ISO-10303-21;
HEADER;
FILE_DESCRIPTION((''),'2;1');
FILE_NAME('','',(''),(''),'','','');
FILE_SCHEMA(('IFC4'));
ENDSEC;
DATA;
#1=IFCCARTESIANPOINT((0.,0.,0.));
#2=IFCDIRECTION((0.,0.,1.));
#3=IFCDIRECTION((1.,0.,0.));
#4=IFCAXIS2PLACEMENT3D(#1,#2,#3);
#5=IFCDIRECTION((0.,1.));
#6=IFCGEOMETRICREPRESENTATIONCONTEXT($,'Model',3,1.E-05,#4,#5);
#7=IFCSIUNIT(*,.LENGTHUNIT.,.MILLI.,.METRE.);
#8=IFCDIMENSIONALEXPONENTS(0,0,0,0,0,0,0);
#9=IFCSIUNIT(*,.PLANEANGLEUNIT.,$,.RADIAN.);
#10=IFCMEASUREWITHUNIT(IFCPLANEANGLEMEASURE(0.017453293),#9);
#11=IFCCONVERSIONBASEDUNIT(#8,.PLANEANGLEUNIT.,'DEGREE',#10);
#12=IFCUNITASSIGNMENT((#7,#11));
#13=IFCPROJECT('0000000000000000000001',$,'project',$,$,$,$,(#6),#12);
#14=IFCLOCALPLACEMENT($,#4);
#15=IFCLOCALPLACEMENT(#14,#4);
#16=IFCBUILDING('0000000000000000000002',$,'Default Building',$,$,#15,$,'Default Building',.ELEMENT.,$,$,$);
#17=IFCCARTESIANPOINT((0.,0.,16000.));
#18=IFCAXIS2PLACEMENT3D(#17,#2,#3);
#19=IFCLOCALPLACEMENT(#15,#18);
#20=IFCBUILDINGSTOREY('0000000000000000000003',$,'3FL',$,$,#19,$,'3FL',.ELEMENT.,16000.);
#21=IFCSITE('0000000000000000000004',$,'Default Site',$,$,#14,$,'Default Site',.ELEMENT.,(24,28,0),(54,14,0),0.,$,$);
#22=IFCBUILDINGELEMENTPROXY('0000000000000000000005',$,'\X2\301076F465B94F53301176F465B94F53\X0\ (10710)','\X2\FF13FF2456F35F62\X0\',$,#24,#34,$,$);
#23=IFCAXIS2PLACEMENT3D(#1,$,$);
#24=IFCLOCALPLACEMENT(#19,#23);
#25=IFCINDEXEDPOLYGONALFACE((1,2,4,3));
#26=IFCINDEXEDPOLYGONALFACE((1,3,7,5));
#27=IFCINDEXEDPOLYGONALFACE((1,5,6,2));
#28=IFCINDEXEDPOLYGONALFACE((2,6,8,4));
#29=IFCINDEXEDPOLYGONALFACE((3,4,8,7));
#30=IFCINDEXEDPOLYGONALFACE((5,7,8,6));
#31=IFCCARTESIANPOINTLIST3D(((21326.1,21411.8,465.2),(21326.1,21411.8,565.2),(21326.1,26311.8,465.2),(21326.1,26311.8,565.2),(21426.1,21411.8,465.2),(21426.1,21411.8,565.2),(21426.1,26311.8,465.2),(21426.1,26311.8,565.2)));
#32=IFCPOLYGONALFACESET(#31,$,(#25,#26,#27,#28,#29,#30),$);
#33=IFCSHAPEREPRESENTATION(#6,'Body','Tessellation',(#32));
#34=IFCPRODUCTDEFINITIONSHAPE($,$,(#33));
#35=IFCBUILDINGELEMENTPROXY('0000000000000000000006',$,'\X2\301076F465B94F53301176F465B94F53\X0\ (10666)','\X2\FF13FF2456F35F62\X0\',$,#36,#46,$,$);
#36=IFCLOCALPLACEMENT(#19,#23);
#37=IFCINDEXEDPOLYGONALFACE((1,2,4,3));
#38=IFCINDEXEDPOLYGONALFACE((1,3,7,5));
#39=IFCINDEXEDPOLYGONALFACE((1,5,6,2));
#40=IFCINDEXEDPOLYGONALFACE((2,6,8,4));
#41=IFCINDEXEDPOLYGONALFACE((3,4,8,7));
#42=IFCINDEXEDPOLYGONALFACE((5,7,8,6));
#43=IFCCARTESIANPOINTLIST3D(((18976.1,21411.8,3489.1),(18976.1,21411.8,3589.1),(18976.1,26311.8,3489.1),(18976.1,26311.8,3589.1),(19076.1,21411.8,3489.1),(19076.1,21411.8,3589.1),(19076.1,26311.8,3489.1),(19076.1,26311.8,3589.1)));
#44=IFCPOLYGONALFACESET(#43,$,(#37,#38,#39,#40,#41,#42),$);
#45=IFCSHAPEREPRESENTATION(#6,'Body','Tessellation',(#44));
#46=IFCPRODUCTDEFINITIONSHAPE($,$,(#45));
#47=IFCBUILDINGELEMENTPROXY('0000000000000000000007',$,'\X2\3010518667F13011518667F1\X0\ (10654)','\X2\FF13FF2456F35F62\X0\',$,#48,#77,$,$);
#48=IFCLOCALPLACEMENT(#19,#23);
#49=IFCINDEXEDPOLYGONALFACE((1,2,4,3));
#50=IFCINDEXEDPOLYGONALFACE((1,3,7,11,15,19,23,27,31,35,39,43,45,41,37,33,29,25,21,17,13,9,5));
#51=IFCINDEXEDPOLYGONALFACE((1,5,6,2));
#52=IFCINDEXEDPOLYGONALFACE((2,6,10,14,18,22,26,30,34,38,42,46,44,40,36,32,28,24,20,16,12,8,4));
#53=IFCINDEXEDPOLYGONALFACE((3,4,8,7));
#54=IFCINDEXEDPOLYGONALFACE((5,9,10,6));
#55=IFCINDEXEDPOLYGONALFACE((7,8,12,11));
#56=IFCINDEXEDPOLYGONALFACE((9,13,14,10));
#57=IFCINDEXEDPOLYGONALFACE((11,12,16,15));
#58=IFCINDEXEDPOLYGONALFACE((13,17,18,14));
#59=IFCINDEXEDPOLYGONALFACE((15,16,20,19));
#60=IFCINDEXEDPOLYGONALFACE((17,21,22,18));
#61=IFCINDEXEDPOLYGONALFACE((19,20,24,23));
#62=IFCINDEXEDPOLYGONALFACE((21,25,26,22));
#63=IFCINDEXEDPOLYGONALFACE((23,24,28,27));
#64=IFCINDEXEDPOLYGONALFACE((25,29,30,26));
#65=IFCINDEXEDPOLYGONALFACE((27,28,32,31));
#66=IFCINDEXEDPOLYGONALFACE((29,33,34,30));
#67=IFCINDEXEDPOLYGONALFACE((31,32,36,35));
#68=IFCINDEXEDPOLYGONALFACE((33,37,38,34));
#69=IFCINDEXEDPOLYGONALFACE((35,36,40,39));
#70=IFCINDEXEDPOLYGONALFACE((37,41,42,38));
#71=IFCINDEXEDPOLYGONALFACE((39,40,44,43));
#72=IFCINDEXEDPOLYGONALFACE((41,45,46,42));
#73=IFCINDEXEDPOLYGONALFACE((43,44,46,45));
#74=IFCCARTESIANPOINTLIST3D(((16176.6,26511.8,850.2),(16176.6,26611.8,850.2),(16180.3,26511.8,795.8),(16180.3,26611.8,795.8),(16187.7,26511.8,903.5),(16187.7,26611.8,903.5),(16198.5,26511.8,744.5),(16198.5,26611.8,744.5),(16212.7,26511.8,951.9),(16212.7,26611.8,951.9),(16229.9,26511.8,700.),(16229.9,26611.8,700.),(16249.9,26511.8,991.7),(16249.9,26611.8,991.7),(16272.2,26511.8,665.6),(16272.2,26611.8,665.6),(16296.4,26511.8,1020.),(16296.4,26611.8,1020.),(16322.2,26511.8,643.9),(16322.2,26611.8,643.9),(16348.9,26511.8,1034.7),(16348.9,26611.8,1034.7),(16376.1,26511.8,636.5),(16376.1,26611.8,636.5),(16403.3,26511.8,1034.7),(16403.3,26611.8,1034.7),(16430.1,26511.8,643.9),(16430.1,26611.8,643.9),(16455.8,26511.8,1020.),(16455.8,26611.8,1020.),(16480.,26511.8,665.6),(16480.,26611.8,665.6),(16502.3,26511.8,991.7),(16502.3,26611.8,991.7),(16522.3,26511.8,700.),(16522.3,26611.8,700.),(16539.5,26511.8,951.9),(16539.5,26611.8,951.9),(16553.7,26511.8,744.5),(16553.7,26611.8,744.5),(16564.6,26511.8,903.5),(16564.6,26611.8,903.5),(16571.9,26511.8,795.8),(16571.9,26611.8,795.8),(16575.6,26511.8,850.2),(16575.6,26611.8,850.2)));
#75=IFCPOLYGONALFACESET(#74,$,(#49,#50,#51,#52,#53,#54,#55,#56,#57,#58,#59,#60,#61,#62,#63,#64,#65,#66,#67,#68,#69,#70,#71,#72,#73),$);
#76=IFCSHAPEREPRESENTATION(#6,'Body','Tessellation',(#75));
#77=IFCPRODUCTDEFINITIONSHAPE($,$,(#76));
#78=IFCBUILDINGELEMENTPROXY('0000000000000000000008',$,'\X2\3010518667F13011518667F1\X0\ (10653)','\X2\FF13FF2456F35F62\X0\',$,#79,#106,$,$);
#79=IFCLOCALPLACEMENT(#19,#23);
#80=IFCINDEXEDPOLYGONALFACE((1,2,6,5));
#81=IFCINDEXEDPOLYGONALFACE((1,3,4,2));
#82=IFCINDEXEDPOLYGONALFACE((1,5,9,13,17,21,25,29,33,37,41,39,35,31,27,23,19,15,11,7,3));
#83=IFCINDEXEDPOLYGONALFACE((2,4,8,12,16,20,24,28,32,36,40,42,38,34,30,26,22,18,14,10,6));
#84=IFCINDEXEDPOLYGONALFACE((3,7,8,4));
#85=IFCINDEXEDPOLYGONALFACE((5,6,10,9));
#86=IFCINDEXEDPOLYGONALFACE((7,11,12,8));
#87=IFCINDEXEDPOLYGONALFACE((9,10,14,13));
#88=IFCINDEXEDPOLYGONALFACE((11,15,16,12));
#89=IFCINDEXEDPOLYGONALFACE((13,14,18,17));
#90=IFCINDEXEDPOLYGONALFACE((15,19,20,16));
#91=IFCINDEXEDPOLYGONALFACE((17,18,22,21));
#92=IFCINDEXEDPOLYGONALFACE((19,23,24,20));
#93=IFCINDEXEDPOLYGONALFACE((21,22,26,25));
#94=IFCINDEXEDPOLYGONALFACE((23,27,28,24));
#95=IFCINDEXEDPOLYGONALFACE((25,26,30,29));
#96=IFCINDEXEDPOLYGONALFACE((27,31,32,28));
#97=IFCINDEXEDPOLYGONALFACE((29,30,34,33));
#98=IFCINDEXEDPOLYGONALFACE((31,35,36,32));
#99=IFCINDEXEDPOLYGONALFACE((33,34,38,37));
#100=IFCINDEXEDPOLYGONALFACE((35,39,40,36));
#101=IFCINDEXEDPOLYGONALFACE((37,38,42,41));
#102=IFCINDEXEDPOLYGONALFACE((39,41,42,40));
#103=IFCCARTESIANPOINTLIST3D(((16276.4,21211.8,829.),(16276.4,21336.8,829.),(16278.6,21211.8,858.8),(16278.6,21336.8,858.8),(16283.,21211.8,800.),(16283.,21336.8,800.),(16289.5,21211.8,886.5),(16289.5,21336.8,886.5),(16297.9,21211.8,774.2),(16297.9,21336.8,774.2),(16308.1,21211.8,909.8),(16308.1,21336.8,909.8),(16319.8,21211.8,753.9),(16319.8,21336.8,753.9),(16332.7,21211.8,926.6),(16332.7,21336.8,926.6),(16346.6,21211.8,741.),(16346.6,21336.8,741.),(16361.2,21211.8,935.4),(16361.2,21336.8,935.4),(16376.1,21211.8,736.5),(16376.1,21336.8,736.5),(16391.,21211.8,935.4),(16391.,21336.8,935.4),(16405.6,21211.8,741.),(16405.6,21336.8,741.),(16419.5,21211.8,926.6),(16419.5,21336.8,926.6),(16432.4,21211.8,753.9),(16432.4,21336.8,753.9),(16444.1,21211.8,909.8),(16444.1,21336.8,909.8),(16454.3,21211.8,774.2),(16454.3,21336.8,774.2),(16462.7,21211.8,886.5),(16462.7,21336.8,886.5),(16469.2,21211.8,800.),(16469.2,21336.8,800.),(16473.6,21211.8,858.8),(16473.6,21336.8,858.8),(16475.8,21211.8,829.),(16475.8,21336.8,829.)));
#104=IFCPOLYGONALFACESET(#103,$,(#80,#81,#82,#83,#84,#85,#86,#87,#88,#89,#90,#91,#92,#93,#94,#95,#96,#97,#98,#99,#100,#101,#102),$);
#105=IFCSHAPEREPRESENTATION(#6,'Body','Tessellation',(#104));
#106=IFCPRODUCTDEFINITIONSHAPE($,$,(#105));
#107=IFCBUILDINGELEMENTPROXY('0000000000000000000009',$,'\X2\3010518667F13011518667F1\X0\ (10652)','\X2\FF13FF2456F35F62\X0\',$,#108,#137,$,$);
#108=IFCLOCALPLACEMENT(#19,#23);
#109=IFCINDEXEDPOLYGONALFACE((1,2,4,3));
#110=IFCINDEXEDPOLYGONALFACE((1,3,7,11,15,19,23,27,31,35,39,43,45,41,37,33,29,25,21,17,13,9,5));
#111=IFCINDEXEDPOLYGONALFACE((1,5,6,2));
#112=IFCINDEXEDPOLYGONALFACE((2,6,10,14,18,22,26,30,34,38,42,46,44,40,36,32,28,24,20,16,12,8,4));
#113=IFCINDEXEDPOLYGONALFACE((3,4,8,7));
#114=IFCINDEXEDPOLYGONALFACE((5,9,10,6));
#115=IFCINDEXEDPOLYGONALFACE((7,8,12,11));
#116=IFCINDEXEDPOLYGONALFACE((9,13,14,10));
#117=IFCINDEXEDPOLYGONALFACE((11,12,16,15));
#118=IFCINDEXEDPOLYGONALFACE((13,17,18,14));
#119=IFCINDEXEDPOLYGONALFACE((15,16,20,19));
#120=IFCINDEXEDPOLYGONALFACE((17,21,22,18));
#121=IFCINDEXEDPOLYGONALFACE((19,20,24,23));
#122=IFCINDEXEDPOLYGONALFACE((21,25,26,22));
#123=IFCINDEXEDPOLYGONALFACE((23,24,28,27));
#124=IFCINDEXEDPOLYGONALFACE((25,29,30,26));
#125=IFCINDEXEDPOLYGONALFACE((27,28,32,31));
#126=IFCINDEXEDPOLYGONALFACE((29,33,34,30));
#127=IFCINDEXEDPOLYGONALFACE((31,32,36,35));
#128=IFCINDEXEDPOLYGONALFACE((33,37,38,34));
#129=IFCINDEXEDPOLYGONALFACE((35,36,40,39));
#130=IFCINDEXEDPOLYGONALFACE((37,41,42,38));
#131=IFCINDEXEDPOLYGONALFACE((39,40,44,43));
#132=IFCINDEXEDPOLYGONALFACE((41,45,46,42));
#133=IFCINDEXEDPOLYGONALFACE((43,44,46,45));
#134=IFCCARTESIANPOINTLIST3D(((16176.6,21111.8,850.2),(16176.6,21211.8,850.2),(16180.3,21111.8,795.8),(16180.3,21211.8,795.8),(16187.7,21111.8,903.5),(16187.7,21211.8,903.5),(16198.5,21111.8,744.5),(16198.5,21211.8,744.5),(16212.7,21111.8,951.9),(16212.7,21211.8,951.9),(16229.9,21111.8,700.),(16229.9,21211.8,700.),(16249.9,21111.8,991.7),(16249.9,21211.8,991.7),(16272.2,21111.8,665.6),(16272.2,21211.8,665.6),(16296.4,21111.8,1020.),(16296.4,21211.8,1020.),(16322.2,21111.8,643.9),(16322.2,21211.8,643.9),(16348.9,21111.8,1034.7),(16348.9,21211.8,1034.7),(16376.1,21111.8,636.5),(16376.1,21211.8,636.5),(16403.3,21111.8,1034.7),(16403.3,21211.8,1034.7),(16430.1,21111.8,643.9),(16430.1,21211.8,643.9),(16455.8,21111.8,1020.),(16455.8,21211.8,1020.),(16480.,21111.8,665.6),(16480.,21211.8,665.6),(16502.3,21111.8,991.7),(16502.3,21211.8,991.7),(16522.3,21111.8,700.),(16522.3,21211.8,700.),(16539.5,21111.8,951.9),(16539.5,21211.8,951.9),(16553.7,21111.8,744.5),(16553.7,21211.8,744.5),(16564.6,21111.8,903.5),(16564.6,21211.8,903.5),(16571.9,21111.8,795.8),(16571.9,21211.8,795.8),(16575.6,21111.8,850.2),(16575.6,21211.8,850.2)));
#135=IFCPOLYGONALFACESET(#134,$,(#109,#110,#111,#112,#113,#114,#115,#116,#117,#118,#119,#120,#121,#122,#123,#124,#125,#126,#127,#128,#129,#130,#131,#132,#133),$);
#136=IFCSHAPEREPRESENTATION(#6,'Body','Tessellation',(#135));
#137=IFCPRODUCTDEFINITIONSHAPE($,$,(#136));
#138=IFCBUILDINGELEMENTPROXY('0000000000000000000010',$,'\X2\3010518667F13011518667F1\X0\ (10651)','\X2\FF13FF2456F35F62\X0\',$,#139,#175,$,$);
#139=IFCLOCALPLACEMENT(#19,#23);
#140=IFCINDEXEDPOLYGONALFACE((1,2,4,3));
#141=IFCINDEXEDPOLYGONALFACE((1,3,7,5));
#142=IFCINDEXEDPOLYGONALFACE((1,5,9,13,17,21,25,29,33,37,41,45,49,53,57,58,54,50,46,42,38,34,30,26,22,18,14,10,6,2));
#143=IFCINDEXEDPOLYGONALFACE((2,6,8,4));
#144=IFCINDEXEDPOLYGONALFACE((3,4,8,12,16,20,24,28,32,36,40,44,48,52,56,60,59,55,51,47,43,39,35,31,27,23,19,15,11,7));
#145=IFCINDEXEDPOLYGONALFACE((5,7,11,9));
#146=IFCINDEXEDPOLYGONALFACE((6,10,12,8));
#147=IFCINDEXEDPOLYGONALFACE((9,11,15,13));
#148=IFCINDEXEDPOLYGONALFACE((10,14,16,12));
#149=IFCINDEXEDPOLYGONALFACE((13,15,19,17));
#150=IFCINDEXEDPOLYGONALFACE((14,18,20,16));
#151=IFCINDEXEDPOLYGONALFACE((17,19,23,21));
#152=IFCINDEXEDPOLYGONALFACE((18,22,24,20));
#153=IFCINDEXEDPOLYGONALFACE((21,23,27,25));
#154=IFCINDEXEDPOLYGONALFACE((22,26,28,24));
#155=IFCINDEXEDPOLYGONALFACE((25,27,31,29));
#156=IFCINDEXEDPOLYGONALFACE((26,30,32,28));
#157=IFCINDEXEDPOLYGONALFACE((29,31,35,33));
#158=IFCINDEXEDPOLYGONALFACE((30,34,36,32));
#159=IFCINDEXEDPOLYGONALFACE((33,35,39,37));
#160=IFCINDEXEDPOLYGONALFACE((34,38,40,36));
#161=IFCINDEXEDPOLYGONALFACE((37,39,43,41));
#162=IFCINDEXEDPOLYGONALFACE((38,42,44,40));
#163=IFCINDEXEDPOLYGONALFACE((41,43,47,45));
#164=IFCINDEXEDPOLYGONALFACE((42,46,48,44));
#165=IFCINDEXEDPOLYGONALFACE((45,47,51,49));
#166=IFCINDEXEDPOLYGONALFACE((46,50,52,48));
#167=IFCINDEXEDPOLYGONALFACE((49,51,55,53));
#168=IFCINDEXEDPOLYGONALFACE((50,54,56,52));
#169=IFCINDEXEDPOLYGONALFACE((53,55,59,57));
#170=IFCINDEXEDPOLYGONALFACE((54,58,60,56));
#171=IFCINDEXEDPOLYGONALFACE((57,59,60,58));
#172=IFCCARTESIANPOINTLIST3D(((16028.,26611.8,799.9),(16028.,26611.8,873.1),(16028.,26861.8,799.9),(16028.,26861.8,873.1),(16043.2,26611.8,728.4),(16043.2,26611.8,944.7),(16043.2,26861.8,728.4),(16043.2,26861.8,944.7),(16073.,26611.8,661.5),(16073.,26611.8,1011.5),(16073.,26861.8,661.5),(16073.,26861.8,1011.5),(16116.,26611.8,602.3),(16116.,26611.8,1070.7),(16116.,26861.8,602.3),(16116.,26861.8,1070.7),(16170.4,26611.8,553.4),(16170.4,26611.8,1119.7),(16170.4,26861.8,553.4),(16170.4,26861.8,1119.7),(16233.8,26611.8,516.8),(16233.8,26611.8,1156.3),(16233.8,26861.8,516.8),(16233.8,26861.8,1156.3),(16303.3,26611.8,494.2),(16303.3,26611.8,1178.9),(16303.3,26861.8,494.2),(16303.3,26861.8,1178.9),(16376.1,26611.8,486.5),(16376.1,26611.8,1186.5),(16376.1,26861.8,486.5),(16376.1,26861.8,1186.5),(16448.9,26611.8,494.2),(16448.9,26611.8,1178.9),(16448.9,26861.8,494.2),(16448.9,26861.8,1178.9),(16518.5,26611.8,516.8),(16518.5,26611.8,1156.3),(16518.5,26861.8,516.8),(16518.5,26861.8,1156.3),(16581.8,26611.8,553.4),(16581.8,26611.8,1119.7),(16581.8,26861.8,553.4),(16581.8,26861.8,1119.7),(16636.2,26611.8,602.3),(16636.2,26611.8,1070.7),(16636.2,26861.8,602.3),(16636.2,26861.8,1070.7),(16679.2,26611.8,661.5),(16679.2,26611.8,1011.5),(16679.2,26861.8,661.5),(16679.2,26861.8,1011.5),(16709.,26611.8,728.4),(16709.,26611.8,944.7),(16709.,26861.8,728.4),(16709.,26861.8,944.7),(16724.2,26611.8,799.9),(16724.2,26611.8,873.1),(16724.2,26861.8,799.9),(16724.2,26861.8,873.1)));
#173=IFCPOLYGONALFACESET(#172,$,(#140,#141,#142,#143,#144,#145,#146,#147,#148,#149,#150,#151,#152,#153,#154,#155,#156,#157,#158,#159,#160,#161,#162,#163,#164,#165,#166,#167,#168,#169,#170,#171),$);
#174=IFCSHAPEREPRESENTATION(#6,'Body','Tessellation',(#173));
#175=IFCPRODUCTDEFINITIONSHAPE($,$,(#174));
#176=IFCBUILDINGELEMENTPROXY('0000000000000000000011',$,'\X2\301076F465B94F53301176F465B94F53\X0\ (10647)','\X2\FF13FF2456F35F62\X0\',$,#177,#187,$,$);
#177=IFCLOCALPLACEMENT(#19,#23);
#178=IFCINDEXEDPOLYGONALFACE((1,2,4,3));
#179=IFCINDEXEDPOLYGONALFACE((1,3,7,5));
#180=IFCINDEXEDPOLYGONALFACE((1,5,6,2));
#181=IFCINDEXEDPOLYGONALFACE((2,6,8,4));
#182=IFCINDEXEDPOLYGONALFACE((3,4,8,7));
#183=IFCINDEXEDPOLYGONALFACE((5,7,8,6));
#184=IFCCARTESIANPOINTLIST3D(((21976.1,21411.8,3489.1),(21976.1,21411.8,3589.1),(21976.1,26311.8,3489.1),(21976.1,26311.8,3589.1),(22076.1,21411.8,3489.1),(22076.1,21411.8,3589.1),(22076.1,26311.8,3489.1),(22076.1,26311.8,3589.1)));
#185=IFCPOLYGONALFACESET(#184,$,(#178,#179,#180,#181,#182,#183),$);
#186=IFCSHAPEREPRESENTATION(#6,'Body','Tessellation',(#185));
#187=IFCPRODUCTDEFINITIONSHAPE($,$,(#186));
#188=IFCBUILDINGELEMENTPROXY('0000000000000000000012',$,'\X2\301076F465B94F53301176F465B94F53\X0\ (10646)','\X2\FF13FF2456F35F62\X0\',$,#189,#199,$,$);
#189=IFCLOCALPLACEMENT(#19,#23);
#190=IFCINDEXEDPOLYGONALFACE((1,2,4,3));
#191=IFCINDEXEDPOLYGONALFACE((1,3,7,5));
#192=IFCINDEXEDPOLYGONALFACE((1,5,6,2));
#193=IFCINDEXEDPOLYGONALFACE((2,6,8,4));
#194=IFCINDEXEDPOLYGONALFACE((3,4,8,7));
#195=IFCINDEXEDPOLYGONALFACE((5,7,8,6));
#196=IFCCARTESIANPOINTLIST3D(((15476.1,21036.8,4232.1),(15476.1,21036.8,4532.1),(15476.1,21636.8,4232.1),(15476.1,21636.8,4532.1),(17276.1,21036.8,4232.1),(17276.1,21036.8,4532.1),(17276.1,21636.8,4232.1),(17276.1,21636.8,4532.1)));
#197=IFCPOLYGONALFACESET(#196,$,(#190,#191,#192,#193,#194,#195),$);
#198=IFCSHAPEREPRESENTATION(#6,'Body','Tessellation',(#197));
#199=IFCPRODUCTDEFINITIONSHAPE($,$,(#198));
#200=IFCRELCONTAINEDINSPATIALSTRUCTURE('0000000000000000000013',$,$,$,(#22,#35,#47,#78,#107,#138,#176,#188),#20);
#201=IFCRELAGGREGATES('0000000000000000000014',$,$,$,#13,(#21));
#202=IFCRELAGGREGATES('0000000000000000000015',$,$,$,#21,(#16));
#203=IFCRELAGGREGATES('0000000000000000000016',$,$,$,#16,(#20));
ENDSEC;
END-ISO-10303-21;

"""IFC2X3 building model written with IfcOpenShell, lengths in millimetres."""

from ifc_helpers import new_model, entity, si_unit, converted_unit, direction, frame, origin_with_axes, origin_2d_with_axis, place, context, project, spatial, rectangle, circle, extrude, source, transform, mapped, element, save


model = new_model("IFC2X3")

# Units and contexts
model_context = context("Model", 3, precision=1e-05, world=origin_with_axes(), true_north=direction((0.0, 1.0)))
ifc_project = project(units=[si_unit("LENGTHUNIT", "METRE", prefix="MILLI"), converted_unit("PLANEANGLEUNIT", "DEGREE", entity("IfcPlaneAngleMeasure", 0.017453293), si_unit("PLANEANGLEUNIT", "RADIAN"), dimensions=[0, 0, 0, 0, 0, 0, 0])], contexts=[model_context])

# Site, building, storey
site_placement = place(None, origin_with_axes())
site = spatial("IfcSite", under=ifc_project, at=site_placement, Name="Default Site", LongName="Default Site", CompositionType="ELEMENT", RefLatitude=(24, 28, 0), RefLongitude=(54, 14, 0), RefElevation=0.0)
building_placement = place(site_placement, origin_with_axes())
building = spatial("IfcBuilding", under=site, at=building_placement, Name="Default Building", LongName="Default Building", CompositionType="ELEMENT")
storey_placement = place(building_placement, frame((0.0, 0.0, 16000.0), z_axis=(0.0, 0.0, 1.0), x_axis=(1.0, 0.0, 0.0)))
storey = spatial("IfcBuildingStorey", under=building, at=storey_placement, Name="3FL", LongName="3FL", CompositionType="ELEMENT", Elevation=16000.0)

# Building element proxies
shared_shape_1 = source(origin_with_axes(), model_context, "Body", "SweptSolid", [
    extrude(rectangle(XDim=100.0, YDim=4900.0, at=origin_2d_with_axis()), origin_with_axes(), (0.0, 0.0, 1.0), 100.0),
])
proxy_1_placement = place(storey_placement, frame((21376.1, 23861.8, 465.2), z_axis=(0.0, 0.0, 1.0), x_axis=(1.0, 0.0, 0.0)))
element("IfcBuildingElementProxy", 1, at=proxy_1_placement, inside=storey, Name="【直方体】直方体 (10710)", Description="３Ｄ図形", context=model_context, shape_type="MappedRepresentation", body=[
    mapped(shared_shape_1, transform((0.0, 0.0, 0.0))),
])
shared_shape_2 = source(origin_with_axes(), model_context, "Body", "SweptSolid", [
    extrude(rectangle(XDim=100.0, YDim=4900.0, at=origin_2d_with_axis()), origin_with_axes(), (0.0, 0.0, 1.0), 100.0),
])
proxy_2_placement = place(storey_placement, frame((19026.1, 23861.8, 3489.1), z_axis=(0.0, 0.0, 1.0), x_axis=(1.0, 0.0, 0.0)))
element("IfcBuildingElementProxy", 2, at=proxy_2_placement, inside=storey, Name="【直方体】直方体 (10666)", Description="３Ｄ図形", context=model_context, shape_type="MappedRepresentation", body=[
    mapped(shared_shape_2, transform((0.0, 0.0, 0.0))),
])
shared_shape_3 = source(origin_with_axes(), model_context, "Body", "SweptSolid", [
    extrude(circle(Radius=200.0, at=origin_2d_with_axis()), frame((0.0, 0.0, 0.0), z_axis=(0.0, 0.0, 1.0), x_axis=(1.0, 0.0, 0.0)), (0.0, 0.0, 1.0), 100.0),
])
proxy_3_placement = place(storey_placement, frame((16376.1, 26511.8, 836.5), z_axis=(0.0, 1.0, 0.0), x_axis=(0.0, 0.0, -1.0)))
element("IfcBuildingElementProxy", 3, at=proxy_3_placement, inside=storey, Name="【円柱】円柱 (10654)", Description="３Ｄ図形", context=model_context, shape_type="MappedRepresentation", body=[
    mapped(shared_shape_3, transform((0.0, 0.0, 0.0))),
])
shared_shape_4 = source(origin_with_axes(), model_context, "Body", "SweptSolid", [
    extrude(circle(Radius=100.0, at=origin_2d_with_axis()), frame((0.0, 0.0, 0.0), z_axis=(0.0, 0.0, 1.0), x_axis=(1.0, 0.0, 0.0)), (0.0, 0.0, 1.0), 125.0),
])
proxy_4_placement = place(storey_placement, frame((16376.1, 21211.8, 836.5), z_axis=(0.0, 1.0, 0.0), x_axis=(0.0, 0.0, -1.0)))
element("IfcBuildingElementProxy", 4, at=proxy_4_placement, inside=storey, Name="【円柱】円柱 (10653)", Description="３Ｄ図形", context=model_context, shape_type="MappedRepresentation", body=[
    mapped(shared_shape_4, transform((0.0, 0.0, 0.0))),
])
shared_shape_5 = source(origin_with_axes(), model_context, "Body", "SweptSolid", [
    extrude(circle(Radius=200.0, at=origin_2d_with_axis()), frame((0.0, 0.0, 0.0), z_axis=(0.0, 0.0, 1.0), x_axis=(1.0, 0.0, 0.0)), (0.0, 0.0, 1.0), 100.0),
])
proxy_5_placement = place(storey_placement, frame((16376.1, 21111.8, 836.5), z_axis=(0.0, 1.0, 0.0), x_axis=(0.0, 0.0, -1.0)))
element("IfcBuildingElementProxy", 5, at=proxy_5_placement, inside=storey, Name="【円柱】円柱 (10652)", Description="３Ｄ図形", context=model_context, shape_type="MappedRepresentation", body=[
    mapped(shared_shape_5, transform((0.0, 0.0, 0.0))),
])
shared_shape_6 = source(origin_with_axes(), model_context, "Body", "SweptSolid", [
    extrude(circle(Radius=350.0, at=origin_2d_with_axis()), frame((0.0, 0.0, 0.0), z_axis=(0.0, 0.0, 1.0), x_axis=(1.0, 0.0, 0.0)), (0.0, 0.0, 1.0), 250.0),
])
proxy_6_placement = place(storey_placement, frame((16376.1, 26611.8, 836.5), z_axis=(0.0, 1.0, 0.0), x_axis=(0.0, 0.0, -1.0)))
element("IfcBuildingElementProxy", 6, at=proxy_6_placement, inside=storey, Name="【円柱】円柱 (10651)", Description="３Ｄ図形", context=model_context, shape_type="MappedRepresentation", body=[
    mapped(shared_shape_6, transform((0.0, 0.0, 0.0))),
])
shared_shape_7 = source(origin_with_axes(), model_context, "Body", "SweptSolid", [
    extrude(rectangle(XDim=100.0, YDim=4900.0, at=origin_2d_with_axis()), origin_with_axes(), (0.0, 0.0, 1.0), 100.0),
])
proxy_7_placement = place(storey_placement, frame((22026.1, 23861.8, 3489.1), z_axis=(0.0, 0.0, 1.0), x_axis=(1.0, 0.0, 0.0)))
element("IfcBuildingElementProxy", 7, at=proxy_7_placement, inside=storey, Name="【直方体】直方体 (10647)", Description="３Ｄ図形", context=model_context, shape_type="MappedRepresentation", body=[
    mapped(shared_shape_7, transform((0.0, 0.0, 0.0))),
])
shared_shape_8 = source(origin_with_axes(), model_context, "Body", "SweptSolid", [
    extrude(rectangle(XDim=1800.0, YDim=600.0, at=origin_2d_with_axis()), origin_with_axes(), (0.0, 0.0, 1.0), 300.0),
])
proxy_8_placement = place(storey_placement, frame((16376.1, 21336.8, 4232.1), z_axis=(0.0, 0.0, 1.0), x_axis=(1.0, 0.0, 0.0)))
element("IfcBuildingElementProxy", 8, at=proxy_8_placement, inside=storey, Name="【直方体】直方体 (10646)", Description="３Ｄ図形", context=model_context, shape_type="MappedRepresentation", body=[
    mapped(shared_shape_8, transform((0.0, 0.0, 0.0))),
])

save(model, "model.ifc")
